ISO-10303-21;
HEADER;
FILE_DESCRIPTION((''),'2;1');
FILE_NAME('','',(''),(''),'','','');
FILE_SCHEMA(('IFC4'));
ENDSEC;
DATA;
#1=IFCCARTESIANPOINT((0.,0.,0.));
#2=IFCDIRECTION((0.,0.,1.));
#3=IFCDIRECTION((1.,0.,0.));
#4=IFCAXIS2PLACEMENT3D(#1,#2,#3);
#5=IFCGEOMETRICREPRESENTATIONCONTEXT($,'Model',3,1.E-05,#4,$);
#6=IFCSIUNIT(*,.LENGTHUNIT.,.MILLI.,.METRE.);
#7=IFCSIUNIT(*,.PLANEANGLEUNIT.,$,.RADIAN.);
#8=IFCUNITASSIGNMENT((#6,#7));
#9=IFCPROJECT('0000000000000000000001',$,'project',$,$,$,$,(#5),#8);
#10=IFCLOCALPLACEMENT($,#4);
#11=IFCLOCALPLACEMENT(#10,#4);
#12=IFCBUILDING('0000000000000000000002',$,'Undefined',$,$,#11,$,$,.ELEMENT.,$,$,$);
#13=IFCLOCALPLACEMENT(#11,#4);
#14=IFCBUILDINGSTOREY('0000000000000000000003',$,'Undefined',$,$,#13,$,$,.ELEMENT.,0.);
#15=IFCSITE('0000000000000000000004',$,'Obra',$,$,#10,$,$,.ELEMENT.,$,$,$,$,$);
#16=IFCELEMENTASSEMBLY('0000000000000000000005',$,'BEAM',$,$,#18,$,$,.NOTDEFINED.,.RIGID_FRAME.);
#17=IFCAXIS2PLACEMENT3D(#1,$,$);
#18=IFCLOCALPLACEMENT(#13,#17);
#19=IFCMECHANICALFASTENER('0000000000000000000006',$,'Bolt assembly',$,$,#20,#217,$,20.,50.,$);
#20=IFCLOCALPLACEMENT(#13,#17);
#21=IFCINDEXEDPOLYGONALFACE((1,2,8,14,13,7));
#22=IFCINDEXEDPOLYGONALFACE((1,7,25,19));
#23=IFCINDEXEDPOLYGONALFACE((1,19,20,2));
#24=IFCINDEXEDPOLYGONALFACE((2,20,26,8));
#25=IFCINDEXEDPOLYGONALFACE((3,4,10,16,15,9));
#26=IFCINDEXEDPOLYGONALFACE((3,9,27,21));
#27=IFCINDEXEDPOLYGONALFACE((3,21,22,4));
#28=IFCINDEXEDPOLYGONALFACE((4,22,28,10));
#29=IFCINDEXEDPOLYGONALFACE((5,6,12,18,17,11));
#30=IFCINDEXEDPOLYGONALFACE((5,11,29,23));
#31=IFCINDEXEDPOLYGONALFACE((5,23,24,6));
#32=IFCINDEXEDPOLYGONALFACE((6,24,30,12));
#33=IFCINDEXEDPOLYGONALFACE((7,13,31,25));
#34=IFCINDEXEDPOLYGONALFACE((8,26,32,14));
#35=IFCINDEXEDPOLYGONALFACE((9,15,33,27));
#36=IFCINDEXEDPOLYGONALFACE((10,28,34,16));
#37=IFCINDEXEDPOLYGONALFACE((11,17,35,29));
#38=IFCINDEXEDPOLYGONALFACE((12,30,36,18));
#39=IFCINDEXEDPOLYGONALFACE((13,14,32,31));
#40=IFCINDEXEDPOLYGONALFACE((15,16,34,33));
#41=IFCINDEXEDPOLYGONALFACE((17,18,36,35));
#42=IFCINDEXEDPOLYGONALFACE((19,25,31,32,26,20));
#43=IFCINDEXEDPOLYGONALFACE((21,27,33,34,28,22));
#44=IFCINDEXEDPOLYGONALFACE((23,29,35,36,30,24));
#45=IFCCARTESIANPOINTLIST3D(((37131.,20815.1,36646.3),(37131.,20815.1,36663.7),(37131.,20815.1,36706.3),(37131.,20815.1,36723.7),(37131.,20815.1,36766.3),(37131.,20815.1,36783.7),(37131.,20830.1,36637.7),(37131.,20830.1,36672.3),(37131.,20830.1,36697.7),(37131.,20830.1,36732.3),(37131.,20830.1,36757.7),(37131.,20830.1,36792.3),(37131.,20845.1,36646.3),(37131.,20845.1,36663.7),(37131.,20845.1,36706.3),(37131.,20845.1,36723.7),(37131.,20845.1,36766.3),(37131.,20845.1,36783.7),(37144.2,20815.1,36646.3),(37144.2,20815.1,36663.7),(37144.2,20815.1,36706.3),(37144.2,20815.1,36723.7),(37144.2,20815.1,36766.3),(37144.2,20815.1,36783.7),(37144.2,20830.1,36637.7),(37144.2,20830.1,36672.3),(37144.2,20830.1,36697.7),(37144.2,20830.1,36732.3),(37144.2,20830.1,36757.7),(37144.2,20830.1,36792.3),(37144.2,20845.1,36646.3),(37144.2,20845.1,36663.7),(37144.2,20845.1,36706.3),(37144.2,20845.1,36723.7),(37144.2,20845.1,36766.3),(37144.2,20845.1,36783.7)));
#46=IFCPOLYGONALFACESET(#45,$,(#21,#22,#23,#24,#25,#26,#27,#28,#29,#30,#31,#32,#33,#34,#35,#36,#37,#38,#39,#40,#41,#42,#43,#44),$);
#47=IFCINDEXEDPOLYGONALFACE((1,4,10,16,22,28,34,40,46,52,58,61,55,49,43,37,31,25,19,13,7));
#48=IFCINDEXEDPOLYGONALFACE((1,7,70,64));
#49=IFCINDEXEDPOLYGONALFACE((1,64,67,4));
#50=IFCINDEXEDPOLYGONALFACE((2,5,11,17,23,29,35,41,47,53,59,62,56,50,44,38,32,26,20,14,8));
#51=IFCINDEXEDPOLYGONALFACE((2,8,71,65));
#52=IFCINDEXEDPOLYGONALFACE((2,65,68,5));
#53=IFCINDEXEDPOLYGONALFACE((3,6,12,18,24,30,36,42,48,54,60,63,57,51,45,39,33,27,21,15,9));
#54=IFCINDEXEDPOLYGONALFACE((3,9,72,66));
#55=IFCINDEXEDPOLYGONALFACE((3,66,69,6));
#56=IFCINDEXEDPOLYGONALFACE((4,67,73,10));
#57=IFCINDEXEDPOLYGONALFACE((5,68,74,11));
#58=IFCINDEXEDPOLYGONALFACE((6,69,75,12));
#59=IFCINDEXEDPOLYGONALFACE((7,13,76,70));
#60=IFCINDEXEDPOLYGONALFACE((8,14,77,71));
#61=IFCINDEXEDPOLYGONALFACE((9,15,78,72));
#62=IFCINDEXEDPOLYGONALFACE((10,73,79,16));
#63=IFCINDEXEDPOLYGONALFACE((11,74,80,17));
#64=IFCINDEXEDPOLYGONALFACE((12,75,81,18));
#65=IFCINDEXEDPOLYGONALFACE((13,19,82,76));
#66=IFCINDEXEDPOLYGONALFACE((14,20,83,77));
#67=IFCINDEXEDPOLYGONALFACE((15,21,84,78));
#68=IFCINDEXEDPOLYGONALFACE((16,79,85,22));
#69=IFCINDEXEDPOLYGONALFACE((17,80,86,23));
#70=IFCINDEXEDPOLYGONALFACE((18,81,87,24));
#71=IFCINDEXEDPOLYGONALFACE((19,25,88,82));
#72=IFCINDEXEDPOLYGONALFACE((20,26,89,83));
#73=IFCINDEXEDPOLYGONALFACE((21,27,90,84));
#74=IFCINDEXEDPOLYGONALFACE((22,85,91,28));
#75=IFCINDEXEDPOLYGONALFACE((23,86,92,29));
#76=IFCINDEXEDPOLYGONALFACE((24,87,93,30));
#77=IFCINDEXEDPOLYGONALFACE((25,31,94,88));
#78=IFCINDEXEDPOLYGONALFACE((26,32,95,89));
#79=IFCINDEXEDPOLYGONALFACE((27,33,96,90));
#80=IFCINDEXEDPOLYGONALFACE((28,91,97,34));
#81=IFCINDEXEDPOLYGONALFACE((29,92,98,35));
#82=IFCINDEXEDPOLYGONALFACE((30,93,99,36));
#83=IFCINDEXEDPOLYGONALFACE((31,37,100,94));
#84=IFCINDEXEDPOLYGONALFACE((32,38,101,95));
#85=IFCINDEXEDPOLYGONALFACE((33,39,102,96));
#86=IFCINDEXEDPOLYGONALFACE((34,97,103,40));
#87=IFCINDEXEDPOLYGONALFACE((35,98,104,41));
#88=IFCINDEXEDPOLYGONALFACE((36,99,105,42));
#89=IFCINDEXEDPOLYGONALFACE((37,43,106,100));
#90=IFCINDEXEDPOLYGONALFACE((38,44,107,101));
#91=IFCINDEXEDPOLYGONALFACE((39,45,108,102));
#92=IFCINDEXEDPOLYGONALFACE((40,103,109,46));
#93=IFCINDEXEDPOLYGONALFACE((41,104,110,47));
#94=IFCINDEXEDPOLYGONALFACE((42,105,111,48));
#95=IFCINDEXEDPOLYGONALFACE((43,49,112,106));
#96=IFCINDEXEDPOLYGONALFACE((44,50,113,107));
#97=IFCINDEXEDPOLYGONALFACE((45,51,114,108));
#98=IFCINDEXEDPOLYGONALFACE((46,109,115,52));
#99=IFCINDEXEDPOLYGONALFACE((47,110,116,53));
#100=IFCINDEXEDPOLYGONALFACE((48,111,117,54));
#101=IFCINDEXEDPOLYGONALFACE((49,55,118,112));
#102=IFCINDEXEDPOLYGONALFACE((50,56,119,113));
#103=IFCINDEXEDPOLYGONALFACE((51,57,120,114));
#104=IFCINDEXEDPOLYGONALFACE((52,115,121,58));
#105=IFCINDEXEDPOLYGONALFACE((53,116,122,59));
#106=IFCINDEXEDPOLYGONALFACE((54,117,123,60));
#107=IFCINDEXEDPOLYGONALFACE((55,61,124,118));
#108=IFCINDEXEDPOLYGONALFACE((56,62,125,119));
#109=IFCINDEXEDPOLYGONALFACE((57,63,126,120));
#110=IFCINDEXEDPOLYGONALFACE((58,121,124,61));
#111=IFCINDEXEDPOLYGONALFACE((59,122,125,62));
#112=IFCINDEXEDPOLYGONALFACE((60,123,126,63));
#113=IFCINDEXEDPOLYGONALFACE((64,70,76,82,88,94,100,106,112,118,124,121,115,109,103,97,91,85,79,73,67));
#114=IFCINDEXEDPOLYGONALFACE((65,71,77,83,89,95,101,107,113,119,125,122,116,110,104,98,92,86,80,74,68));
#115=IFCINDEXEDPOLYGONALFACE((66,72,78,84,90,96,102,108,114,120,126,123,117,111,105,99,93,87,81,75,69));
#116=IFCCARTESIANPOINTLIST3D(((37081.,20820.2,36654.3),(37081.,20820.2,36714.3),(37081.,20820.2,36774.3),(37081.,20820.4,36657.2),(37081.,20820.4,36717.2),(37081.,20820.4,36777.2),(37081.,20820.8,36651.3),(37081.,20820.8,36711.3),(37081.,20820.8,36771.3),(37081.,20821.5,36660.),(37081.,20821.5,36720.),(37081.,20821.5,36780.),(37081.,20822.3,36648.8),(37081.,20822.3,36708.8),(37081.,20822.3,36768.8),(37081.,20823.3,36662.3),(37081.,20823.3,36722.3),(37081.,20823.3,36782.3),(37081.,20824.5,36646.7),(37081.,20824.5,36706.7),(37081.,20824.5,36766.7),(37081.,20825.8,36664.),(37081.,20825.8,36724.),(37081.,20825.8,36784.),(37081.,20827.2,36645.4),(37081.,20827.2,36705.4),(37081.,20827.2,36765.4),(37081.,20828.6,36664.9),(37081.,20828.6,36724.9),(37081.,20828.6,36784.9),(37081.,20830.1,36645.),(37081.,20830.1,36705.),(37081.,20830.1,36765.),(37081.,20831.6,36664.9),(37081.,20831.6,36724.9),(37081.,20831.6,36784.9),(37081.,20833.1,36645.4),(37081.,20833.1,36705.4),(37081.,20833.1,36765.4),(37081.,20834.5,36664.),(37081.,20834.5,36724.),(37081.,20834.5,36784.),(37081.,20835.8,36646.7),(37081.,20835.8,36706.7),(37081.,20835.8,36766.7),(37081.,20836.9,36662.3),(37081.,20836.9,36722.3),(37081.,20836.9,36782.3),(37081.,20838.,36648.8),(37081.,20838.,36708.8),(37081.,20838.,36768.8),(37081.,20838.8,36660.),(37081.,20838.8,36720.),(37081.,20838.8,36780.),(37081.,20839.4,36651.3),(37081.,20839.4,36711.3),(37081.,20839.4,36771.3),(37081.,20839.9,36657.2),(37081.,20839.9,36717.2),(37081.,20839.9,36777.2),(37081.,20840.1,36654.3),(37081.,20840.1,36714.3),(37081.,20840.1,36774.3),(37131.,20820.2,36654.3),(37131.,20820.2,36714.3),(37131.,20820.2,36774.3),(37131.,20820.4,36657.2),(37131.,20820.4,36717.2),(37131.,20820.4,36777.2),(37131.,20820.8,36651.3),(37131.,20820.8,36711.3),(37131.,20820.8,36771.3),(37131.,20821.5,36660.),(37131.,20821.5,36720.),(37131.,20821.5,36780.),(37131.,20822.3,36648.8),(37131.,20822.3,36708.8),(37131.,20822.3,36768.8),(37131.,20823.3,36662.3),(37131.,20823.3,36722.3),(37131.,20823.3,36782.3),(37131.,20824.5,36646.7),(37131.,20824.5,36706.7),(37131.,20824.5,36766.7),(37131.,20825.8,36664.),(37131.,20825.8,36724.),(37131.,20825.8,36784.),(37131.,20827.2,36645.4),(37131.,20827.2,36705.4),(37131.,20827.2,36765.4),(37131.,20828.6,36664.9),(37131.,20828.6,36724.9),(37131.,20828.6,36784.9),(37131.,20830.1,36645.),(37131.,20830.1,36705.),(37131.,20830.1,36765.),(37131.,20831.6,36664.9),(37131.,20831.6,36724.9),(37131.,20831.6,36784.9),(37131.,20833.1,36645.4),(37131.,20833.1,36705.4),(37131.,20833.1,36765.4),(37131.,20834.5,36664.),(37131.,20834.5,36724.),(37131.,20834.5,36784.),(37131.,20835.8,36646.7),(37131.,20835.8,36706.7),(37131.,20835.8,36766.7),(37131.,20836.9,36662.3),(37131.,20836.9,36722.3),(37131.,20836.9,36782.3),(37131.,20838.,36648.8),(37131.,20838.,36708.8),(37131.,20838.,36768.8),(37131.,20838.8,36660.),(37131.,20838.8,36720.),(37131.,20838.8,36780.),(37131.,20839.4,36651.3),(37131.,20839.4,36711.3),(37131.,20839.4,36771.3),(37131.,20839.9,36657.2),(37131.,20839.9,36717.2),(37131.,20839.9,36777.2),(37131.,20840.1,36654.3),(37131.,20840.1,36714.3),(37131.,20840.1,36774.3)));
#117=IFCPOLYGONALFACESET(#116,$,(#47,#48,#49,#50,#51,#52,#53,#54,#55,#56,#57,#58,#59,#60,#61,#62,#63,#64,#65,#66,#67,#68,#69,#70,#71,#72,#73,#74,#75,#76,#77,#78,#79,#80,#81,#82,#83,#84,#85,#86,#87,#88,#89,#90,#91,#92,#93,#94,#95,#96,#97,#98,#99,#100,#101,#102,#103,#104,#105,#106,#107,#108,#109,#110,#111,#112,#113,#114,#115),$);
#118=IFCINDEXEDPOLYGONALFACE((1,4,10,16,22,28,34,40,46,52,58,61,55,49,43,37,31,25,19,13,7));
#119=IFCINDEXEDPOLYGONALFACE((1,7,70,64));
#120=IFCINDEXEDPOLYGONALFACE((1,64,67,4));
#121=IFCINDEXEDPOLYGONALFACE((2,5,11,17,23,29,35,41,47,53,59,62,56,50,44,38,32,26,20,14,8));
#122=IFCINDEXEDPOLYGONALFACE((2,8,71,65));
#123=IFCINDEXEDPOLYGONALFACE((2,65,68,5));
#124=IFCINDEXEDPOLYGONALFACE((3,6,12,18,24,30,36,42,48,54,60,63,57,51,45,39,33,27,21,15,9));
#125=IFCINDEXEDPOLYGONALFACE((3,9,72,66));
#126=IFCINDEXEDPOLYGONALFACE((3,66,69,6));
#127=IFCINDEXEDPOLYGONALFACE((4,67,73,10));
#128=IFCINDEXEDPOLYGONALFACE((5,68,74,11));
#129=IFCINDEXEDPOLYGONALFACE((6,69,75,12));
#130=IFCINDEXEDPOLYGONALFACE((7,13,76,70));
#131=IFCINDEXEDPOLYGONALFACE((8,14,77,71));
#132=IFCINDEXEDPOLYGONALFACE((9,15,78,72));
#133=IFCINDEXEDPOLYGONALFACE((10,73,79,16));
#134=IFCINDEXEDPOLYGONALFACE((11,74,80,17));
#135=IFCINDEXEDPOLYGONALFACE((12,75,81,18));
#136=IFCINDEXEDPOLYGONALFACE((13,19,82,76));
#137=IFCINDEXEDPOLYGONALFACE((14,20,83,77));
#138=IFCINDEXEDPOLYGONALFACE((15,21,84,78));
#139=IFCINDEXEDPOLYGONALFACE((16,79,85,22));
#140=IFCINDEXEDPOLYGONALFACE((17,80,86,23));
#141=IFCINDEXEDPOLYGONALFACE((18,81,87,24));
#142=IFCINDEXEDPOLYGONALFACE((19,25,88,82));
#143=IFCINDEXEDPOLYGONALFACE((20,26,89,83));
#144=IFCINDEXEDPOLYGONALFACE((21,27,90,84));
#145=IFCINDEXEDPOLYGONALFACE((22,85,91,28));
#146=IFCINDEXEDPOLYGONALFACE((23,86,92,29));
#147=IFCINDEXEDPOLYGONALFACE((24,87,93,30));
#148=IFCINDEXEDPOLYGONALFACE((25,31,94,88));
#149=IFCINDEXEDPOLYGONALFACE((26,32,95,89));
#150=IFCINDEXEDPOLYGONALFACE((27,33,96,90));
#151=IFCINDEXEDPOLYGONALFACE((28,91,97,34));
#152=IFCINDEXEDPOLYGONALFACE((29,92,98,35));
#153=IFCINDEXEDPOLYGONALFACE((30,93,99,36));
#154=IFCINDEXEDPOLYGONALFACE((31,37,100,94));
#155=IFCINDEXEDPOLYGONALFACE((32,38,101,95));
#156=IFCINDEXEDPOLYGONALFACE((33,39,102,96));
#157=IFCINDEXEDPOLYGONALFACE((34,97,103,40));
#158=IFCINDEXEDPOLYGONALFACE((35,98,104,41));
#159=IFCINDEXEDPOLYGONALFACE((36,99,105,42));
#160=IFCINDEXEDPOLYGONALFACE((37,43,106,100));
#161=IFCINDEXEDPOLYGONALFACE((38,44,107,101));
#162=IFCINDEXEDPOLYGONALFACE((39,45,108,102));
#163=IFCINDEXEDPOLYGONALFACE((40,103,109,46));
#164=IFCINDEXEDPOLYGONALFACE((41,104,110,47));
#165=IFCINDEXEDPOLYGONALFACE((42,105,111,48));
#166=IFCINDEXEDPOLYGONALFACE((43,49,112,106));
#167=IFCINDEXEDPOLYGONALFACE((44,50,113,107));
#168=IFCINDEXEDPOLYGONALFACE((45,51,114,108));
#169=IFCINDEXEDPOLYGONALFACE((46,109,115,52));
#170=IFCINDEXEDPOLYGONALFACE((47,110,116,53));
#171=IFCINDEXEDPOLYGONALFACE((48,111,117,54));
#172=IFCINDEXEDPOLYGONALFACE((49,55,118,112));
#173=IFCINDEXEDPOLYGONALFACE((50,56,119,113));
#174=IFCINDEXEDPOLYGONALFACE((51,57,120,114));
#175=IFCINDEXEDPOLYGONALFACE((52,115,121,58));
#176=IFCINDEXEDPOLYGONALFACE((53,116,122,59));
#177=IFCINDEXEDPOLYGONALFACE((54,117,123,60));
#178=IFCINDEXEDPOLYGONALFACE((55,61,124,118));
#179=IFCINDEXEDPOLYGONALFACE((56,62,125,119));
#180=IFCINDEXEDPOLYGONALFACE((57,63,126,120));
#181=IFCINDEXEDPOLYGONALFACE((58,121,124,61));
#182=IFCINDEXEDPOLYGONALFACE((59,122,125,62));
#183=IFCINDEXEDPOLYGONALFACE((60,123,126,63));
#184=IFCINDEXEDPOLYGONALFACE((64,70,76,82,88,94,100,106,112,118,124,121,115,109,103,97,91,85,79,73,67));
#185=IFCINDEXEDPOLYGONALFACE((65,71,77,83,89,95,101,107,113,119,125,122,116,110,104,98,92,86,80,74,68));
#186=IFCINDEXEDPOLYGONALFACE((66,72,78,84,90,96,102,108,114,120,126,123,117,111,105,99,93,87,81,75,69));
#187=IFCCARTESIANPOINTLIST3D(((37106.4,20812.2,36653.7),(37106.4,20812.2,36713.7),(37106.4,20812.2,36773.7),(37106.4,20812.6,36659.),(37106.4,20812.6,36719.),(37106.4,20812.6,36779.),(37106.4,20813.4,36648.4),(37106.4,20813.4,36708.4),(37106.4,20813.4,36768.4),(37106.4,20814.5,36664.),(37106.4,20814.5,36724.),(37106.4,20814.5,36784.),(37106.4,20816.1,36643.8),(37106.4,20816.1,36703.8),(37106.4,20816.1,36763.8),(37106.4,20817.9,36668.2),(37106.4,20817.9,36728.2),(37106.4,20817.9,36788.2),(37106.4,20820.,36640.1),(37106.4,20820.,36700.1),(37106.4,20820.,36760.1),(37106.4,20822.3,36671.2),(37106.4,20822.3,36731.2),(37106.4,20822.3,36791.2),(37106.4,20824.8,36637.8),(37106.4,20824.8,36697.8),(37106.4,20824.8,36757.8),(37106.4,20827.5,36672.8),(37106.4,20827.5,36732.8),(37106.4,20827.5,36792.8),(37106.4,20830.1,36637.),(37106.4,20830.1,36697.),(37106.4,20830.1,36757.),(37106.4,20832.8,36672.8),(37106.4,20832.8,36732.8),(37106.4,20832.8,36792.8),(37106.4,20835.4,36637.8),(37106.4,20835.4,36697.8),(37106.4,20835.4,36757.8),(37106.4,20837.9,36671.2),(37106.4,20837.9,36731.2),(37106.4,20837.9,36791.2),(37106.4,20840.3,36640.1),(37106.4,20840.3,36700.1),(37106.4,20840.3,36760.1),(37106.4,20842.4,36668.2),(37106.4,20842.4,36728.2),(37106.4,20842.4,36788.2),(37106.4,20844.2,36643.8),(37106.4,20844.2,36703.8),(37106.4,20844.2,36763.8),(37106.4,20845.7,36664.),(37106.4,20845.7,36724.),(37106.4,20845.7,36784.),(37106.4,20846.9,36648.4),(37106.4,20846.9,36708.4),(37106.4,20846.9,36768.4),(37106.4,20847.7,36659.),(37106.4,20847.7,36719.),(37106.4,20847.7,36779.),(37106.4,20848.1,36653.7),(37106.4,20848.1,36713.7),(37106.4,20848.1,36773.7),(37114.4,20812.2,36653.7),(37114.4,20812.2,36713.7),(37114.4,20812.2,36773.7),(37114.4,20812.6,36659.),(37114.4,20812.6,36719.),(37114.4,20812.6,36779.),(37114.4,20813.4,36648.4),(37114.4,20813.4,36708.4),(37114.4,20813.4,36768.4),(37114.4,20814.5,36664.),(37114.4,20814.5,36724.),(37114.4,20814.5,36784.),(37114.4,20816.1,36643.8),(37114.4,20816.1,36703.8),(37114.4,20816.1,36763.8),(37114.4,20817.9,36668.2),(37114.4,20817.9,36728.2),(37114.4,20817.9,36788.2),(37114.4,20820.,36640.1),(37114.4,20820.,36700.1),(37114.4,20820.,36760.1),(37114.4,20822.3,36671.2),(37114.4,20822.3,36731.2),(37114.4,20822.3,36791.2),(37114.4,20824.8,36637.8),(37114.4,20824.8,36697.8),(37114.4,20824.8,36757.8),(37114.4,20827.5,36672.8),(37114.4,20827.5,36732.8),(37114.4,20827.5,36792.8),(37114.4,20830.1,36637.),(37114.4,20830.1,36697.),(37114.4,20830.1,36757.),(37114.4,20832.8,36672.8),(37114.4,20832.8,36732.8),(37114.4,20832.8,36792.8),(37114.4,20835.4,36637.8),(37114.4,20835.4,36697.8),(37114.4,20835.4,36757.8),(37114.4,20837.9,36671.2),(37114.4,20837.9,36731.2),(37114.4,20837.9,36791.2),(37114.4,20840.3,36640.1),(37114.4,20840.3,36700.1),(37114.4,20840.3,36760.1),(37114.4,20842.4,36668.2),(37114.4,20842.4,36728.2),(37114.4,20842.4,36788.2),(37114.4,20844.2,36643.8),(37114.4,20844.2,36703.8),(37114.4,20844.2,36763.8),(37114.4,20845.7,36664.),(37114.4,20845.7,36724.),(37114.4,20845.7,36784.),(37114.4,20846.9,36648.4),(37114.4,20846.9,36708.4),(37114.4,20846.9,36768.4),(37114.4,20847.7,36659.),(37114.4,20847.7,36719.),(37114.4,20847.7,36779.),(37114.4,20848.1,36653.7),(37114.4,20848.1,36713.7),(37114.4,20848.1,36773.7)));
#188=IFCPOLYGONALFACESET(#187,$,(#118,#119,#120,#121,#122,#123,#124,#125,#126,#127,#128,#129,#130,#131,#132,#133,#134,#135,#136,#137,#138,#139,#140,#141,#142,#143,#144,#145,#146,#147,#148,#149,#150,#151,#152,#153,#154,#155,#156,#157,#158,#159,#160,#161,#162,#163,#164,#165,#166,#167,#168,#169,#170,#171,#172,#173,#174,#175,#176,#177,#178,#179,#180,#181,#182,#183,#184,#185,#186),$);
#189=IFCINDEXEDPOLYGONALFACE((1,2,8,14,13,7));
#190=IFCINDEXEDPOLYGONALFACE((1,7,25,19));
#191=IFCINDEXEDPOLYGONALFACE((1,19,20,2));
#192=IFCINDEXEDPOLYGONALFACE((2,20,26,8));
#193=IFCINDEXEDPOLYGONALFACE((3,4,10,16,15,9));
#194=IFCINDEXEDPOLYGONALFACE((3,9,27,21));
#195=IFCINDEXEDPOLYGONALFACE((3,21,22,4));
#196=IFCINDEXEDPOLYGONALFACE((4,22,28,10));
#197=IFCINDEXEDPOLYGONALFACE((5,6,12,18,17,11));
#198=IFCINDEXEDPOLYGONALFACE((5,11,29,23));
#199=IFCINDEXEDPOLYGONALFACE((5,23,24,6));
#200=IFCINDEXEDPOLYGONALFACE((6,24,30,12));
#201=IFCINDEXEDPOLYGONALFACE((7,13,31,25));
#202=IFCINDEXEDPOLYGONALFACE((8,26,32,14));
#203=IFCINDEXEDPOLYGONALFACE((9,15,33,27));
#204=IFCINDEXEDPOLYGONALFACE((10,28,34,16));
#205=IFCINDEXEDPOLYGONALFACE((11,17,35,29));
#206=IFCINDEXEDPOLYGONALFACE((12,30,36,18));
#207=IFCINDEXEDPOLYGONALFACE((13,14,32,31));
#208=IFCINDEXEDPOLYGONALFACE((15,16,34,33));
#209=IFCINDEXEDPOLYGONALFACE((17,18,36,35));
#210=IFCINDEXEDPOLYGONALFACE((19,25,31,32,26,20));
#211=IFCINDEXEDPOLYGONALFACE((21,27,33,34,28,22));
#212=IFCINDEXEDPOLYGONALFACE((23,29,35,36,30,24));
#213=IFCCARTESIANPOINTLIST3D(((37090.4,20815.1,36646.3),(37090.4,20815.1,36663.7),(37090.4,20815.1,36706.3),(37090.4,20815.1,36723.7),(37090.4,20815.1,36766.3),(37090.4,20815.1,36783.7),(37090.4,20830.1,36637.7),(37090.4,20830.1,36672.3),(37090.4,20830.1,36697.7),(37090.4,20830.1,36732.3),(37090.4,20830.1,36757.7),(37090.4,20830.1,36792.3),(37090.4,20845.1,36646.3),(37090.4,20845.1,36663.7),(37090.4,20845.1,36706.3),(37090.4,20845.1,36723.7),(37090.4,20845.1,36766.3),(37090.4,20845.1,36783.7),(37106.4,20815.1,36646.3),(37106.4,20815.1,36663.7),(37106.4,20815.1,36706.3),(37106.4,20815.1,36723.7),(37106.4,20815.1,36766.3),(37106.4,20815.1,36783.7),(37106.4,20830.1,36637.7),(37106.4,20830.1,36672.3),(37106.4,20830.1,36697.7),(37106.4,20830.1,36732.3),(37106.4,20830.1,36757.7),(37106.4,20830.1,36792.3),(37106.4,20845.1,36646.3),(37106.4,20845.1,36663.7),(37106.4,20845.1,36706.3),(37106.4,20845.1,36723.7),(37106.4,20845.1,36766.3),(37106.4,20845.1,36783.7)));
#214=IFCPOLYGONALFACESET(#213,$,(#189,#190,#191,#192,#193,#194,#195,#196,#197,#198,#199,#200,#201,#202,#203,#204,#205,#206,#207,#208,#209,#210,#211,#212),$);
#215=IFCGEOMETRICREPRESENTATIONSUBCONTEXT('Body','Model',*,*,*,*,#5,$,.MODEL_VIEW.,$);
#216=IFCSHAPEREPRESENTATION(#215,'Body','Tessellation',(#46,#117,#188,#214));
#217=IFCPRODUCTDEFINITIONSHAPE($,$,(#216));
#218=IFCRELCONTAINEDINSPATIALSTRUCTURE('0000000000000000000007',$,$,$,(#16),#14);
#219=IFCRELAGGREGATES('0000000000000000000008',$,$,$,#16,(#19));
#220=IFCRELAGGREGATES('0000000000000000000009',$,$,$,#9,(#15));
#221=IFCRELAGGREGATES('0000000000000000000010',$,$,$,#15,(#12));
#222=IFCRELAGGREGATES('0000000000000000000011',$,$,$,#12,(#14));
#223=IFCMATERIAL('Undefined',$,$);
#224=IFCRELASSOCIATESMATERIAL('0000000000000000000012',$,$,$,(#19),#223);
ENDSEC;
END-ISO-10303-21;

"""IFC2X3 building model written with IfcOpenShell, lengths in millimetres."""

from ifc_helpers import new_model, si_unit, frame, origin_with_axes, origin_2d_with_axis, place, context, subcontext, project, spatial, polyline, circle, outline, extrude, source, transform, mapped, material, element, aggregate, save


model = new_model("IFC2X3")

# Units and contexts
model_context = context("Model", 3, precision=1e-05, world=origin_with_axes())
body_context = subcontext(model_context, "Body", "Model", "MODEL_VIEW")
ifc_project = project(units=[si_unit("LENGTHUNIT", "METRE", prefix="MILLI"), si_unit("PLANEANGLEUNIT", "RADIAN")], contexts=[model_context])

# Site, building, storey
site_placement = place(None, origin_with_axes())
site = spatial("IfcSite", under=ifc_project, at=site_placement, Name="Obra", CompositionType="ELEMENT")
building_placement = place(site_placement, origin_with_axes())
building = spatial("IfcBuilding", under=site, at=building_placement, Name="Undefined", CompositionType="ELEMENT")
storey_placement = place(building_placement, origin_with_axes())
storey = spatial("IfcBuildingStorey", under=building, at=storey_placement, Name="Undefined", CompositionType="ELEMENT", Elevation=0.0)

# Element assembly
assembly_1_placement = place(storey_placement, origin_with_axes())
assembly_1 = element("IfcElementAssembly", 1, at=assembly_1_placement, inside=storey, Name="BEAM", AssemblyPlace="NOTDEFINED", PredefinedType="RIGID_FRAME")

# Mechanical fastener
ifc_material_1 = material(Name="Undefined")
shared_shape_1 = source(origin_with_axes(), body_context, "Body", "SweptSolid", [
    extrude(outline(polyline([(17.3, 0.0), (8.7, 15.0), (-8.7, 15.0), (-17.3, 0.0), (-8.7, -15.0), (8.7, -15.0), (17.3, 0.0)])), frame((0.0, -26.5, 0.0), z_axis=(0.0, 1.0, 0.0), x_axis=(1.0, 0.0, 0.0)), (0.0, 0.0, 1.0), 13.2),
    extrude(circle(Radius=10.0, at=origin_2d_with_axis()), frame((0.0, -13.3, 0.0), z_axis=(0.0, 1.0, 0.0), x_axis=(1.0, 0.0, 0.0)), (0.0, 0.0, 1.0), 50.0),
    extrude(circle(Radius=18.0, at=origin_2d_with_axis()), frame((0.0, 3.3, 0.0), z_axis=(0.0, 1.0, 0.0), x_axis=(1.0, 0.0, 0.0)), (0.0, 0.0, 1.0), 8.0),
    extrude(outline(polyline([(17.3, 0.0), (8.7, 15.0), (-8.7, 15.0), (-17.3, 0.0), (-8.7, -15.0), (8.7, -15.0), (17.3, 0.0)])), frame((0.0, 11.3, 0.0), z_axis=(0.0, 1.0, 0.0), x_axis=(1.0, 0.0, 0.0)), (0.0, 0.0, 1.0), 16.0),
])
mechanical_fastener_1_placement = place(assembly_1_placement, frame((37117.7, 20780.1, 36815.0), z_axis=(0.0, 1.0, 0.0), x_axis=(0.0, 0.0, -1.0)))
mechanical_fastener_1 = element("IfcMechanicalFastener", 2, at=mechanical_fastener_1_placement, material=ifc_material_1, Name="Bolt assembly", NominalDiameter=20.0, NominalLength=50.0, context=body_context, shape_type="MappedRepresentation", body=[
    mapped(shared_shape_1, transform((40.0, 0.0, 50.0))),
    mapped(shared_shape_1, transform((100.0, 0.0, 50.0))),
    mapped(shared_shape_1, transform((160.0, 0.0, 50.0))),
])
aggregate(assembly_1, [mechanical_fastener_1])

save(model, "model.ifc")
